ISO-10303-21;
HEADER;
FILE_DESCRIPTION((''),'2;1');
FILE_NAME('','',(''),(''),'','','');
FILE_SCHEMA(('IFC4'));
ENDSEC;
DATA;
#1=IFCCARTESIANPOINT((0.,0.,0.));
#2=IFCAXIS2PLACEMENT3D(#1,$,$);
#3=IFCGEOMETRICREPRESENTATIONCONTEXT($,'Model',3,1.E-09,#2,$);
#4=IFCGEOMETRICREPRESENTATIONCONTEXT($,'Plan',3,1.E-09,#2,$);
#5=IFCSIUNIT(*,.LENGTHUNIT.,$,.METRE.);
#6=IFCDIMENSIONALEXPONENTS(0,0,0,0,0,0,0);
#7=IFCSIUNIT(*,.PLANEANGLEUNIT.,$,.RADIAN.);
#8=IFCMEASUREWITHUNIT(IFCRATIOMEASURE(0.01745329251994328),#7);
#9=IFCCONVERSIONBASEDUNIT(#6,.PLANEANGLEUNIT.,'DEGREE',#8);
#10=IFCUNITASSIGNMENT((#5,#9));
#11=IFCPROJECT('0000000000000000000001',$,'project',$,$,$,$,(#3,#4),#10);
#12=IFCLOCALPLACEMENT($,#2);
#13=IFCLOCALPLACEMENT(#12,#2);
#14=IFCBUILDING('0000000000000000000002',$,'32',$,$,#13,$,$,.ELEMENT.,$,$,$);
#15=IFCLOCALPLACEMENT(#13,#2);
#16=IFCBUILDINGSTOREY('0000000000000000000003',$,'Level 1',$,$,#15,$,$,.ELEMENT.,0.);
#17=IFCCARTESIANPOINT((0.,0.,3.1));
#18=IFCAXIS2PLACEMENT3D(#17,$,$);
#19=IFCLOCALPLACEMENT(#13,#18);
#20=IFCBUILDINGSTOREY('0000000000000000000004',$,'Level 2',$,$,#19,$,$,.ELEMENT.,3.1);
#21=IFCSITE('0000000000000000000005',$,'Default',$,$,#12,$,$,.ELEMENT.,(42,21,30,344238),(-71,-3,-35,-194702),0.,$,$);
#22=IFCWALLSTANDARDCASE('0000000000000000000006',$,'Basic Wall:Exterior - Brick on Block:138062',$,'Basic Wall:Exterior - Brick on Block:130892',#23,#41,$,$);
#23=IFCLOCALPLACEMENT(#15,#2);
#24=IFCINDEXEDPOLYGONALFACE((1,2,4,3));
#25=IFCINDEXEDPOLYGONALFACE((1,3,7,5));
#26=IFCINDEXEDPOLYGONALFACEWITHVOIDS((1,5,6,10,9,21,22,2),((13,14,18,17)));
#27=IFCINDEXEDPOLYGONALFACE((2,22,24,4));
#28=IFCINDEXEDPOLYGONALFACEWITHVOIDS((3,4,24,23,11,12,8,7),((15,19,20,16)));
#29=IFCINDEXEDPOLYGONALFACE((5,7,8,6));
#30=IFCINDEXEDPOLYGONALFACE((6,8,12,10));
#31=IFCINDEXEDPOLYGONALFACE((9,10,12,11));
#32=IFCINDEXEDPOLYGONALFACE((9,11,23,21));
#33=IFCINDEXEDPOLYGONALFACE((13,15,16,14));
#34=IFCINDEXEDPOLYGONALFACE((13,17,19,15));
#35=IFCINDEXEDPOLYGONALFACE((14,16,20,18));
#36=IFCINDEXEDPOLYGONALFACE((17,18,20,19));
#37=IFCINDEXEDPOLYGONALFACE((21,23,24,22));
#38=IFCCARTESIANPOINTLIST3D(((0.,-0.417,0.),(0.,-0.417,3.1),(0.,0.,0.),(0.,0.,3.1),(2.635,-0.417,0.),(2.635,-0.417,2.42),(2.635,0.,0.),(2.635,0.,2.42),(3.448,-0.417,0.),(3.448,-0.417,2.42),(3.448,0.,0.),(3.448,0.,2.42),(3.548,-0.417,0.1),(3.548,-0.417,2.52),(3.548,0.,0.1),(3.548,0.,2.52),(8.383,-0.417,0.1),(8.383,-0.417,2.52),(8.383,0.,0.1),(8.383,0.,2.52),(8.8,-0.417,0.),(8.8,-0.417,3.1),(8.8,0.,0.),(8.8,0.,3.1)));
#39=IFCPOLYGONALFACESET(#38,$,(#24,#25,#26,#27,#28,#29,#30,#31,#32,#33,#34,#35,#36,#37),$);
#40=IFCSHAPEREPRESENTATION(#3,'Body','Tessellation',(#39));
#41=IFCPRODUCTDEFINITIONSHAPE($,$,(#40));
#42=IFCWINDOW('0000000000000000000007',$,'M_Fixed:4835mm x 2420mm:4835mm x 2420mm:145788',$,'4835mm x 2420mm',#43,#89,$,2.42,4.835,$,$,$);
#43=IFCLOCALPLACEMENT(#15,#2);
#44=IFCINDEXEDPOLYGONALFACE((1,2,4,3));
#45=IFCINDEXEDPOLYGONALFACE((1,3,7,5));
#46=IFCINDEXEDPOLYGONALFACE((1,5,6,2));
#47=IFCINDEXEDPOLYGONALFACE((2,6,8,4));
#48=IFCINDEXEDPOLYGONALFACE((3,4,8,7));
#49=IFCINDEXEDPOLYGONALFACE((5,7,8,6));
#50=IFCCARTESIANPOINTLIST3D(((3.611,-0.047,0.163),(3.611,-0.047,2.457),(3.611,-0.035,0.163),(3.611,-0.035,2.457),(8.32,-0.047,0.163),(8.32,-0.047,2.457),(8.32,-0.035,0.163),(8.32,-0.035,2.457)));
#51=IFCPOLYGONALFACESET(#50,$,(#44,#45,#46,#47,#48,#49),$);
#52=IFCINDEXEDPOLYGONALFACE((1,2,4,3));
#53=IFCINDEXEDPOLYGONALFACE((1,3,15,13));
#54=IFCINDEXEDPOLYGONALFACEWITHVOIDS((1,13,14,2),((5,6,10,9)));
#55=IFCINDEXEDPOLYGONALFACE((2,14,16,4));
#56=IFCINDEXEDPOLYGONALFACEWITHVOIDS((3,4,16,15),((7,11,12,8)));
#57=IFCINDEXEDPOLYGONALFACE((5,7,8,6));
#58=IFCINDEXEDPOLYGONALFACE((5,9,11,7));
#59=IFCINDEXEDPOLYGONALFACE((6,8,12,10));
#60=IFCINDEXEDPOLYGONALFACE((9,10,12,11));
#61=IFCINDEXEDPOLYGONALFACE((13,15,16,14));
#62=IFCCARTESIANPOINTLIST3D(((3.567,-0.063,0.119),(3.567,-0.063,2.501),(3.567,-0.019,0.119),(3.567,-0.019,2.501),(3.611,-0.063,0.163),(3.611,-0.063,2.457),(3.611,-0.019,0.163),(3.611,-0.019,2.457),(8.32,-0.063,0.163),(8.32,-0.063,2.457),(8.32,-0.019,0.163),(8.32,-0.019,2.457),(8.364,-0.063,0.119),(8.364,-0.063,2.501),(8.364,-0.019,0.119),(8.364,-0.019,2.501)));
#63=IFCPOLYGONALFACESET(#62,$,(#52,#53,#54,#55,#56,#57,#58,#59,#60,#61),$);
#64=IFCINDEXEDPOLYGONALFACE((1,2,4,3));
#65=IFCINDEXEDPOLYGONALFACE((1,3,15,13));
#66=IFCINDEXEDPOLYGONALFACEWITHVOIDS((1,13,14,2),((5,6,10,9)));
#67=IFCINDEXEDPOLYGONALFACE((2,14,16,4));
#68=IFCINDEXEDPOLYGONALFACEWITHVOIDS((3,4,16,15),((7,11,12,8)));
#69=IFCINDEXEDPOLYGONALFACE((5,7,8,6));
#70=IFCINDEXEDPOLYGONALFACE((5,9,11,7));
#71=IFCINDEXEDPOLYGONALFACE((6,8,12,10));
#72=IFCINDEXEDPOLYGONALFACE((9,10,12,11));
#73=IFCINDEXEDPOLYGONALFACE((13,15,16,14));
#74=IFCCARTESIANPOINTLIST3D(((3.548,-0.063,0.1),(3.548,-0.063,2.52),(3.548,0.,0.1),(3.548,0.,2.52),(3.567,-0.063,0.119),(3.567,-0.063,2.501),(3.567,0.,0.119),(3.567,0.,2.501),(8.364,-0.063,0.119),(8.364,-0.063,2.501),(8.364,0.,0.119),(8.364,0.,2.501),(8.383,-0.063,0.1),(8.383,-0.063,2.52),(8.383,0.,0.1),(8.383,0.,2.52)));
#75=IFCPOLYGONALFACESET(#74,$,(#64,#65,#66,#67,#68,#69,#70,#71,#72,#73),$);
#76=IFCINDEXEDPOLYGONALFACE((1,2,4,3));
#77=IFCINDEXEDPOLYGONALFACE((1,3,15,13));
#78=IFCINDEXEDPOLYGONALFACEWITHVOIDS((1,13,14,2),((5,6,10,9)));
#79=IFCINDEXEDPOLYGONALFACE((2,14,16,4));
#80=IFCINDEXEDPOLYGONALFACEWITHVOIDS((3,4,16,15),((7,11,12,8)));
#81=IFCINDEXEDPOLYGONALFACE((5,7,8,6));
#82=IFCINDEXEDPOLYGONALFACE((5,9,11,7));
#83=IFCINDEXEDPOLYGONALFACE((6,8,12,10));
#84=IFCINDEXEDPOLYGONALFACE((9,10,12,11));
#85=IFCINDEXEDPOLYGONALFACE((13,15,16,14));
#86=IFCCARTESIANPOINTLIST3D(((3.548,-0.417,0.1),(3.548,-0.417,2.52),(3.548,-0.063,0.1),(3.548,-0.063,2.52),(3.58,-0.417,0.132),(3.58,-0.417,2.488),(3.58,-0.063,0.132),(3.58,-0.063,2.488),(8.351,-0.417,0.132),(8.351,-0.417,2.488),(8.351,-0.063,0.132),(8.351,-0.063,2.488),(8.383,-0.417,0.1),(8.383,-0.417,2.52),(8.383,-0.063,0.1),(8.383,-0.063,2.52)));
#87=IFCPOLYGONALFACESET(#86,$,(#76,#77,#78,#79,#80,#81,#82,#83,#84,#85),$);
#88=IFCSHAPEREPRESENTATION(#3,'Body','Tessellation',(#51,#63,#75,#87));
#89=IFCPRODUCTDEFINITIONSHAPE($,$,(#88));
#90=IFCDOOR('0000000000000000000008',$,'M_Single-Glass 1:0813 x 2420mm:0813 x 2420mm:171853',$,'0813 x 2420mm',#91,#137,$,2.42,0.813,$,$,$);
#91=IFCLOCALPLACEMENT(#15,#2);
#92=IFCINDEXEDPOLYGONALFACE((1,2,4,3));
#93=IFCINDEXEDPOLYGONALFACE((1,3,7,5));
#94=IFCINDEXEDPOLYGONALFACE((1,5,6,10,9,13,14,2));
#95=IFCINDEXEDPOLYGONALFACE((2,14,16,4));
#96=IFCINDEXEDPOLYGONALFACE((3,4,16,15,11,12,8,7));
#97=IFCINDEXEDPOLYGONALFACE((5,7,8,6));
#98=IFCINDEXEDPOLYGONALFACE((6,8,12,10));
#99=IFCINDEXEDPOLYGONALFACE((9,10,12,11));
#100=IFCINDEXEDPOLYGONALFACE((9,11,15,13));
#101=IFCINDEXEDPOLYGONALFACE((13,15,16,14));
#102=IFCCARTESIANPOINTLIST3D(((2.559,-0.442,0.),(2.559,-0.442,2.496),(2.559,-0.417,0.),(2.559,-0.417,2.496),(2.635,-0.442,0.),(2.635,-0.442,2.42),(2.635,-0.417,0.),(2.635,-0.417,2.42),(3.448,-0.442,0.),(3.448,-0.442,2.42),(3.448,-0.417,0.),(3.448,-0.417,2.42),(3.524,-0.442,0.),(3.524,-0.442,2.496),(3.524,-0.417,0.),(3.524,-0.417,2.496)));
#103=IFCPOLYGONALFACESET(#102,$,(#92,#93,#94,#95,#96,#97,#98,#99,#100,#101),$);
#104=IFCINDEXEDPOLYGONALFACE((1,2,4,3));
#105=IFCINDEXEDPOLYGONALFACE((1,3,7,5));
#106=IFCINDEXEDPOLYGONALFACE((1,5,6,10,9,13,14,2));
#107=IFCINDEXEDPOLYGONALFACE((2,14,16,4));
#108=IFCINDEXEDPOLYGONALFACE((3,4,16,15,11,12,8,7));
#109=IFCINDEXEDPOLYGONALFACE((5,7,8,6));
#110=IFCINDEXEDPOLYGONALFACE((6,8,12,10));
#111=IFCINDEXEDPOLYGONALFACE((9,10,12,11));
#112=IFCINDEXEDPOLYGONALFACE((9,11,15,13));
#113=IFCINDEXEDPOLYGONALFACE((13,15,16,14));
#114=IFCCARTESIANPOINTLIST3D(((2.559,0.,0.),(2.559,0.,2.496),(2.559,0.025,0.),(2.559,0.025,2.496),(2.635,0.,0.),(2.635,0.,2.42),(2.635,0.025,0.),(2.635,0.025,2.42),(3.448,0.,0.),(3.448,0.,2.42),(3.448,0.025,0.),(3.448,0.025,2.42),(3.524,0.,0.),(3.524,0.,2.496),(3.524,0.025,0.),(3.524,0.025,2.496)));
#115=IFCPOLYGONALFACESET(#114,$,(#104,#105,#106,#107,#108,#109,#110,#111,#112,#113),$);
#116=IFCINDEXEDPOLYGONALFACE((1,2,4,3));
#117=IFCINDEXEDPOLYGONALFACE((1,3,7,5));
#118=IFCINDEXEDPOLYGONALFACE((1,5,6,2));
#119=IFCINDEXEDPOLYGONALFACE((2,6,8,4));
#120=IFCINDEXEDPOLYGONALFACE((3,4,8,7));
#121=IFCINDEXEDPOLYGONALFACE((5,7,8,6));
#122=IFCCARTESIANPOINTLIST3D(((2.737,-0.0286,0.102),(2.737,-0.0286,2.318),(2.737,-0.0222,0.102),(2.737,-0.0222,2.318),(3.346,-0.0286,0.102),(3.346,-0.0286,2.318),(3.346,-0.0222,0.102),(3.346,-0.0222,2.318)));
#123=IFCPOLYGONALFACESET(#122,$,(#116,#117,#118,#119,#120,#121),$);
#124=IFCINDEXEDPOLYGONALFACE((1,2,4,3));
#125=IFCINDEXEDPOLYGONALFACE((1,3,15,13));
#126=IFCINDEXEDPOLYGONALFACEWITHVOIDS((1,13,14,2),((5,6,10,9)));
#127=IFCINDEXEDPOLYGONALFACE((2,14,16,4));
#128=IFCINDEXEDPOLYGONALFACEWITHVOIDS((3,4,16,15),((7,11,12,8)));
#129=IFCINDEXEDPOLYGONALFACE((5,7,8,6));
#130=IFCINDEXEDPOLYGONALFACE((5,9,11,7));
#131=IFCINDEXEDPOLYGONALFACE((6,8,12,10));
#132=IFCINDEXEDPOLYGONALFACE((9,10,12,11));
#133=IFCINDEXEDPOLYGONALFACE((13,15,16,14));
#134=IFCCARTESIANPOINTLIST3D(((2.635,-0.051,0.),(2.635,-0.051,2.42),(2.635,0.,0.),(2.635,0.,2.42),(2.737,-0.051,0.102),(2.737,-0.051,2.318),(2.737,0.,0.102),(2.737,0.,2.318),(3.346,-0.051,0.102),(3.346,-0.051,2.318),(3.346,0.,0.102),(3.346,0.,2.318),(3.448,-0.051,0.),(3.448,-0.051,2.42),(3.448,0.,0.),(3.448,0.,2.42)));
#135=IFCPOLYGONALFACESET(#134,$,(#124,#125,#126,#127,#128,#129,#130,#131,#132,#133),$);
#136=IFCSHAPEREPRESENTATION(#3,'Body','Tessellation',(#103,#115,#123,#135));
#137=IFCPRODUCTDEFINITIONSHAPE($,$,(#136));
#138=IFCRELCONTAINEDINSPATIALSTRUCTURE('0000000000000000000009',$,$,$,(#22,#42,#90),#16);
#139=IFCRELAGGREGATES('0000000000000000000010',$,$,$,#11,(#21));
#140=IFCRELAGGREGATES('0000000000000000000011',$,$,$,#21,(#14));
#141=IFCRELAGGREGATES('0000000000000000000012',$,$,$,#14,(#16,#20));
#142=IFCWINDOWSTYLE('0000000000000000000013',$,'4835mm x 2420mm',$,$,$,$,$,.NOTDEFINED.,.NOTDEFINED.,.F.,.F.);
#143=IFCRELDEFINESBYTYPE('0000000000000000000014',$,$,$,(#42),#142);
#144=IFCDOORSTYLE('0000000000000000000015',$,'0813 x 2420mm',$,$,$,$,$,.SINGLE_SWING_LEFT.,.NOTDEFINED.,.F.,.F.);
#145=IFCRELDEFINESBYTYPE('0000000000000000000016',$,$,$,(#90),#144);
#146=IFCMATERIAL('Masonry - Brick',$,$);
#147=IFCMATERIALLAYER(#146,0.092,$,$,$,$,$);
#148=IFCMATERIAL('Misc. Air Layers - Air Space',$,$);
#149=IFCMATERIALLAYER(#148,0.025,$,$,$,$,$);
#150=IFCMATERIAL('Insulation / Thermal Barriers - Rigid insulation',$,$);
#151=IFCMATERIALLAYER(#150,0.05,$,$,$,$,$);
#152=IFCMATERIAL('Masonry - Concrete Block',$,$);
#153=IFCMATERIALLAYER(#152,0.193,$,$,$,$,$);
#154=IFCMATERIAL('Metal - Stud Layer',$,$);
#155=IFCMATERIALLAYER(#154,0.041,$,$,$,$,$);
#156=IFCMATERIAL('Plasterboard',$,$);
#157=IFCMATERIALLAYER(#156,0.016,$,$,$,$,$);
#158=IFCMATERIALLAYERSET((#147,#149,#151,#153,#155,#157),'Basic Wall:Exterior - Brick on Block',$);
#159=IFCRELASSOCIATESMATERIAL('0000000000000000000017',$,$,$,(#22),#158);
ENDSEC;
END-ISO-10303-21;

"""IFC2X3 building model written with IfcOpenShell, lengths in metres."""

from ifc_helpers import new_model, entity, si_unit, converted_unit, frame, frame_2d, origin, origin_2d_with_axis, place, context, project, spatial, polyline, rectangle, outline, extrude, source, transform, mapped, material, layer, layer_set, layer_usage, type_object, type_shapes, element, fill, save


model = new_model("IFC2X3")

# Units and contexts
model_context = context("Model", 3, precision=1e-09, world=origin())
plan_context = context("Plan", 3, precision=1e-09, world=origin())
ifc_project = project(units=[si_unit("LENGTHUNIT", "METRE"), converted_unit("PLANEANGLEUNIT", "DEGREE", entity("IfcRatioMeasure", 0.01745329251994328), si_unit("PLANEANGLEUNIT", "RADIAN"), dimensions=[0, 0, 0, 0, 0, 0, 0])], contexts=[model_context, plan_context])

# Site, building, storey
site_placement = place(None, origin())
site = spatial("IfcSite", under=ifc_project, at=site_placement, Name="Default", CompositionType="ELEMENT", RefLatitude=(42, 21, 30, 344238), RefLongitude=(-71, -3, -35, -194702), RefElevation=0.0)
building_placement = place(site_placement, origin())
building = spatial("IfcBuilding", under=site, at=building_placement, Name="32", CompositionType="ELEMENT")
storey_1_placement = place(building_placement, origin())
storey_1 = spatial("IfcBuildingStorey", under=building, at=storey_1_placement, Name="Level 1", CompositionType="ELEMENT", Elevation=0.0)

# Wall, openings, window, door
ifc_material_1 = material(Name="Masonry - Brick")
ifc_layer_1 = layer(ifc_material_1, 0.092)
ifc_material_2 = material(Name="Misc. Air Layers - Air Space")
ifc_layer_2 = layer(ifc_material_2, 0.025)
ifc_material_3 = material(Name="Insulation / Thermal Barriers - Rigid insulation")
ifc_layer_3 = layer(ifc_material_3, 0.05)
ifc_material_4 = material(Name="Masonry - Concrete Block")
ifc_layer_4 = layer(ifc_material_4, 0.193)
ifc_material_5 = material(Name="Metal - Stud Layer")
ifc_layer_5 = layer(ifc_material_5, 0.041)
ifc_material_6 = material(Name="Plasterboard")
ifc_layer_6 = layer(ifc_material_6, 0.016)
ifc_layer_set_1 = layer_set([ifc_layer_1, ifc_layer_2, ifc_layer_3, ifc_layer_4, ifc_layer_5, ifc_layer_6], Name="Basic Wall:Exterior - Brick on Block")
ifc_layer_usage_1 = layer_usage(ifc_layer_set_1, "AXIS2", "NEGATIVE", 0.2085)
wall_1_placement = place(storey_1_placement, frame((0.0, -0.2085, 0.0)))
wall_1 = element("IfcWallStandardCase", 1, at=wall_1_placement, inside=storey_1, material=ifc_layer_usage_1, Name="Basic Wall:Exterior - Brick on Block:138062", ObjectType="Basic Wall:Exterior - Brick on Block:130892", context=model_context, shape_type="SweptSolid", body=[
    extrude(rectangle(XDim=8.8, YDim=0.417, at=frame_2d((4.4, 0.0), x_axis=(-1.0, 0.0))), origin(), (0.0, 0.0, 1.0), 3.1),
])
opening_1_placement = place(wall_1_placement, frame((3.548, -0.2085, 0.1)))
opening_1 = element("IfcOpeningElement", 2, at=opening_1_placement, cuts=wall_1, ObjectType="Opening", context=model_context, shape_type="SweptSolid", body=[
    extrude(rectangle(XDim=2.42, YDim=4.835, at=frame_2d((1.21, 2.4175), x_axis=(1.0, 0.0))), frame((0.0, 0.0, 0.0), z_axis=(0.0, 1.0, 0.0), x_axis=(0.0, 0.0, 1.0)), (0.0, 0.0, 1.0), 0.417),
])
opening_2_placement = place(wall_1_placement, frame((2.635, -0.2085, 0.0)))
opening_2 = element("IfcOpeningElement", 3, at=opening_2_placement, cuts=wall_1, ObjectType="Opening", context=model_context, shape_type="SweptSolid", body=[
    extrude(rectangle(XDim=0.813, YDim=2.42, at=frame_2d((1.21, 0.4065), x_axis=(0.0, -1.0))), frame((0.0, 0.0, 0.0), z_axis=(0.0, 1.0, 0.0), x_axis=(0.0, 0.0, 1.0)), (0.0, 0.0, 1.0), 0.417),
])
window_style_1 = type_object("IfcWindowStyle", Name="4835mm x 2420mm", ConstructionType="NOTDEFINED", OperationType="NOTDEFINED", ParameterTakesPrecedence=False, Sizeable=False)
shared_shape_1 = source(origin(), model_context, "Body", "SweptSolid", [
    extrude(rectangle(XDim=0.012, YDim=4.709, at=origin_2d_with_axis()), frame((2.4175, 0.376, 0.063), z_axis=(0.0, 0.0, 1.0), x_axis=(0.0, -1.0, 0.0)), (0.0, 0.0, 1.0), 2.294),
    extrude(outline(polyline([(-2.3985, -1.191), (2.3985, -1.191), (2.3985, 1.191), (-2.3985, 1.191), (-2.3985, -1.191)]), holes=[polyline([(-2.3545, -1.147), (-2.3545, 1.147), (2.3545, 1.147), (2.3545, -1.147), (-2.3545, -1.147)])]), frame((2.4175, 0.354, 1.21), z_axis=(0.0, 1.0, 0.0), x_axis=(1.0, 0.0, 0.0)), (0.0, 0.0, 1.0), 0.044),
    extrude(outline(polyline([(-2.4175, -1.21), (2.4175, -1.21), (2.4175, 1.21), (-2.4175, 1.21), (-2.4175, -1.21)]), holes=[polyline([(-2.3985, -1.191), (-2.3985, 1.191), (2.3985, 1.191), (2.3985, -1.191), (-2.3985, -1.191)])]), frame((2.4175, 0.354, 1.21), z_axis=(0.0, 1.0, 0.0), x_axis=(1.0, 0.0, 0.0)), (0.0, 0.0, 1.0), 0.063),
    extrude(outline(polyline([(-2.4175, -1.21), (2.4175, -1.21), (2.4175, 1.21), (-2.4175, 1.21), (-2.4175, -1.21)]), holes=[polyline([(-2.3855, -1.178), (-2.3855, 1.178), (2.3855, 1.178), (2.3855, -1.178), (-2.3855, -1.178)])]), frame((2.4175, 0.0, 1.21), z_axis=(0.0, 1.0, 0.0), x_axis=(1.0, 0.0, 0.0)), (0.0, 0.0, 1.0), 0.354),
])
type_shapes(window_style_1, [shared_shape_1])
window_1_placement = place(opening_1_placement, origin())
window_1 = element("IfcWindow", 4, at=window_1_placement, inside=storey_1, type_object=window_style_1, Name="M_Fixed:4835mm x 2420mm:4835mm x 2420mm:145788", ObjectType="4835mm x 2420mm", OverallHeight=2.42, OverallWidth=4.835, context=model_context, shape_type="MappedRepresentation", body=[
    mapped(shared_shape_1, transform((0.0, 0.0, 0.0), scale=1.0)),
])
fill(opening_1, window_1)
door_style_1 = type_object("IfcDoorStyle", Name="0813 x 2420mm", ConstructionType="NOTDEFINED", OperationType="SINGLE_SWING_LEFT", ParameterTakesPrecedence=False, Sizeable=False)
shared_shape_2 = source(origin(), model_context, "Body", "SweptSolid", [
    extrude(outline(polyline([(-0.4065, -1.191), (-0.4065, 1.229), (-0.4825, 1.229), (-0.4825, -1.267), (0.4825, -1.267), (0.4825, 1.229), (0.4065, 1.229), (0.4065, -1.191), (-0.4065, -1.191)])), frame((0.4065, 0.0, 1.229), z_axis=(0.0, 1.0, 0.0), x_axis=(1.0, 0.0, 0.0)), (0.0, 0.0, -1.0), 0.025),
    extrude(outline(polyline([(-0.4065, -1.191), (-0.4065, 1.229), (-0.4825, 1.229), (-0.4825, -1.267), (0.4825, -1.267), (0.4825, 1.229), (0.4065, 1.229), (0.4065, -1.191), (-0.4065, -1.191)])), frame((0.4065, 0.442, 1.229), z_axis=(0.0, 1.0, 0.0), x_axis=(1.0, 0.0, 0.0)), (0.0, 0.0, -1.0), 0.025),
    extrude(rectangle(XDim=0.609, YDim=0.0064, at=origin_2d_with_axis()), frame((0.4065, 0.3916, 0.102)), (0.0, 0.0, 1.0), 2.216),
    extrude(outline(polyline([(-1.21, -0.4065), (1.21, -0.4065), (1.21, 0.4065), (-1.21, 0.4065), (-1.21, -0.4065)]), holes=[polyline([(-1.108, 0.3045), (1.108, 0.3045), (1.108, -0.3045), (-1.108, -0.3045), (-1.108, 0.3045)])]), frame((0.4065, 0.417, 1.21), z_axis=(0.0, -1.0, 0.0), x_axis=(0.0, 0.0, -1.0)), (0.0, 0.0, 1.0), 0.051),
])
type_shapes(door_style_1, [shared_shape_2])
door_1_placement = place(opening_2_placement, origin())
door_1 = element("IfcDoor", 5, at=door_1_placement, inside=storey_1, type_object=door_style_1, Name="M_Single-Glass 1:0813 x 2420mm:0813 x 2420mm:171853", ObjectType="0813 x 2420mm", OverallHeight=2.42, OverallWidth=0.813, context=model_context, shape_type="MappedRepresentation", body=[
    mapped(shared_shape_2, transform((0.0, 0.0, 0.0), scale=1.0)),
])
fill(opening_2, door_1)

# Shared definitions
storey_2_placement = place(building_placement, frame((0.0, 0.0, 3.1)))
storey_2 = spatial("IfcBuildingStorey", under=building, at=storey_2_placement, Name="Level 2", CompositionType="ELEMENT", Elevation=3.1)

save(model, "model.ifc")
